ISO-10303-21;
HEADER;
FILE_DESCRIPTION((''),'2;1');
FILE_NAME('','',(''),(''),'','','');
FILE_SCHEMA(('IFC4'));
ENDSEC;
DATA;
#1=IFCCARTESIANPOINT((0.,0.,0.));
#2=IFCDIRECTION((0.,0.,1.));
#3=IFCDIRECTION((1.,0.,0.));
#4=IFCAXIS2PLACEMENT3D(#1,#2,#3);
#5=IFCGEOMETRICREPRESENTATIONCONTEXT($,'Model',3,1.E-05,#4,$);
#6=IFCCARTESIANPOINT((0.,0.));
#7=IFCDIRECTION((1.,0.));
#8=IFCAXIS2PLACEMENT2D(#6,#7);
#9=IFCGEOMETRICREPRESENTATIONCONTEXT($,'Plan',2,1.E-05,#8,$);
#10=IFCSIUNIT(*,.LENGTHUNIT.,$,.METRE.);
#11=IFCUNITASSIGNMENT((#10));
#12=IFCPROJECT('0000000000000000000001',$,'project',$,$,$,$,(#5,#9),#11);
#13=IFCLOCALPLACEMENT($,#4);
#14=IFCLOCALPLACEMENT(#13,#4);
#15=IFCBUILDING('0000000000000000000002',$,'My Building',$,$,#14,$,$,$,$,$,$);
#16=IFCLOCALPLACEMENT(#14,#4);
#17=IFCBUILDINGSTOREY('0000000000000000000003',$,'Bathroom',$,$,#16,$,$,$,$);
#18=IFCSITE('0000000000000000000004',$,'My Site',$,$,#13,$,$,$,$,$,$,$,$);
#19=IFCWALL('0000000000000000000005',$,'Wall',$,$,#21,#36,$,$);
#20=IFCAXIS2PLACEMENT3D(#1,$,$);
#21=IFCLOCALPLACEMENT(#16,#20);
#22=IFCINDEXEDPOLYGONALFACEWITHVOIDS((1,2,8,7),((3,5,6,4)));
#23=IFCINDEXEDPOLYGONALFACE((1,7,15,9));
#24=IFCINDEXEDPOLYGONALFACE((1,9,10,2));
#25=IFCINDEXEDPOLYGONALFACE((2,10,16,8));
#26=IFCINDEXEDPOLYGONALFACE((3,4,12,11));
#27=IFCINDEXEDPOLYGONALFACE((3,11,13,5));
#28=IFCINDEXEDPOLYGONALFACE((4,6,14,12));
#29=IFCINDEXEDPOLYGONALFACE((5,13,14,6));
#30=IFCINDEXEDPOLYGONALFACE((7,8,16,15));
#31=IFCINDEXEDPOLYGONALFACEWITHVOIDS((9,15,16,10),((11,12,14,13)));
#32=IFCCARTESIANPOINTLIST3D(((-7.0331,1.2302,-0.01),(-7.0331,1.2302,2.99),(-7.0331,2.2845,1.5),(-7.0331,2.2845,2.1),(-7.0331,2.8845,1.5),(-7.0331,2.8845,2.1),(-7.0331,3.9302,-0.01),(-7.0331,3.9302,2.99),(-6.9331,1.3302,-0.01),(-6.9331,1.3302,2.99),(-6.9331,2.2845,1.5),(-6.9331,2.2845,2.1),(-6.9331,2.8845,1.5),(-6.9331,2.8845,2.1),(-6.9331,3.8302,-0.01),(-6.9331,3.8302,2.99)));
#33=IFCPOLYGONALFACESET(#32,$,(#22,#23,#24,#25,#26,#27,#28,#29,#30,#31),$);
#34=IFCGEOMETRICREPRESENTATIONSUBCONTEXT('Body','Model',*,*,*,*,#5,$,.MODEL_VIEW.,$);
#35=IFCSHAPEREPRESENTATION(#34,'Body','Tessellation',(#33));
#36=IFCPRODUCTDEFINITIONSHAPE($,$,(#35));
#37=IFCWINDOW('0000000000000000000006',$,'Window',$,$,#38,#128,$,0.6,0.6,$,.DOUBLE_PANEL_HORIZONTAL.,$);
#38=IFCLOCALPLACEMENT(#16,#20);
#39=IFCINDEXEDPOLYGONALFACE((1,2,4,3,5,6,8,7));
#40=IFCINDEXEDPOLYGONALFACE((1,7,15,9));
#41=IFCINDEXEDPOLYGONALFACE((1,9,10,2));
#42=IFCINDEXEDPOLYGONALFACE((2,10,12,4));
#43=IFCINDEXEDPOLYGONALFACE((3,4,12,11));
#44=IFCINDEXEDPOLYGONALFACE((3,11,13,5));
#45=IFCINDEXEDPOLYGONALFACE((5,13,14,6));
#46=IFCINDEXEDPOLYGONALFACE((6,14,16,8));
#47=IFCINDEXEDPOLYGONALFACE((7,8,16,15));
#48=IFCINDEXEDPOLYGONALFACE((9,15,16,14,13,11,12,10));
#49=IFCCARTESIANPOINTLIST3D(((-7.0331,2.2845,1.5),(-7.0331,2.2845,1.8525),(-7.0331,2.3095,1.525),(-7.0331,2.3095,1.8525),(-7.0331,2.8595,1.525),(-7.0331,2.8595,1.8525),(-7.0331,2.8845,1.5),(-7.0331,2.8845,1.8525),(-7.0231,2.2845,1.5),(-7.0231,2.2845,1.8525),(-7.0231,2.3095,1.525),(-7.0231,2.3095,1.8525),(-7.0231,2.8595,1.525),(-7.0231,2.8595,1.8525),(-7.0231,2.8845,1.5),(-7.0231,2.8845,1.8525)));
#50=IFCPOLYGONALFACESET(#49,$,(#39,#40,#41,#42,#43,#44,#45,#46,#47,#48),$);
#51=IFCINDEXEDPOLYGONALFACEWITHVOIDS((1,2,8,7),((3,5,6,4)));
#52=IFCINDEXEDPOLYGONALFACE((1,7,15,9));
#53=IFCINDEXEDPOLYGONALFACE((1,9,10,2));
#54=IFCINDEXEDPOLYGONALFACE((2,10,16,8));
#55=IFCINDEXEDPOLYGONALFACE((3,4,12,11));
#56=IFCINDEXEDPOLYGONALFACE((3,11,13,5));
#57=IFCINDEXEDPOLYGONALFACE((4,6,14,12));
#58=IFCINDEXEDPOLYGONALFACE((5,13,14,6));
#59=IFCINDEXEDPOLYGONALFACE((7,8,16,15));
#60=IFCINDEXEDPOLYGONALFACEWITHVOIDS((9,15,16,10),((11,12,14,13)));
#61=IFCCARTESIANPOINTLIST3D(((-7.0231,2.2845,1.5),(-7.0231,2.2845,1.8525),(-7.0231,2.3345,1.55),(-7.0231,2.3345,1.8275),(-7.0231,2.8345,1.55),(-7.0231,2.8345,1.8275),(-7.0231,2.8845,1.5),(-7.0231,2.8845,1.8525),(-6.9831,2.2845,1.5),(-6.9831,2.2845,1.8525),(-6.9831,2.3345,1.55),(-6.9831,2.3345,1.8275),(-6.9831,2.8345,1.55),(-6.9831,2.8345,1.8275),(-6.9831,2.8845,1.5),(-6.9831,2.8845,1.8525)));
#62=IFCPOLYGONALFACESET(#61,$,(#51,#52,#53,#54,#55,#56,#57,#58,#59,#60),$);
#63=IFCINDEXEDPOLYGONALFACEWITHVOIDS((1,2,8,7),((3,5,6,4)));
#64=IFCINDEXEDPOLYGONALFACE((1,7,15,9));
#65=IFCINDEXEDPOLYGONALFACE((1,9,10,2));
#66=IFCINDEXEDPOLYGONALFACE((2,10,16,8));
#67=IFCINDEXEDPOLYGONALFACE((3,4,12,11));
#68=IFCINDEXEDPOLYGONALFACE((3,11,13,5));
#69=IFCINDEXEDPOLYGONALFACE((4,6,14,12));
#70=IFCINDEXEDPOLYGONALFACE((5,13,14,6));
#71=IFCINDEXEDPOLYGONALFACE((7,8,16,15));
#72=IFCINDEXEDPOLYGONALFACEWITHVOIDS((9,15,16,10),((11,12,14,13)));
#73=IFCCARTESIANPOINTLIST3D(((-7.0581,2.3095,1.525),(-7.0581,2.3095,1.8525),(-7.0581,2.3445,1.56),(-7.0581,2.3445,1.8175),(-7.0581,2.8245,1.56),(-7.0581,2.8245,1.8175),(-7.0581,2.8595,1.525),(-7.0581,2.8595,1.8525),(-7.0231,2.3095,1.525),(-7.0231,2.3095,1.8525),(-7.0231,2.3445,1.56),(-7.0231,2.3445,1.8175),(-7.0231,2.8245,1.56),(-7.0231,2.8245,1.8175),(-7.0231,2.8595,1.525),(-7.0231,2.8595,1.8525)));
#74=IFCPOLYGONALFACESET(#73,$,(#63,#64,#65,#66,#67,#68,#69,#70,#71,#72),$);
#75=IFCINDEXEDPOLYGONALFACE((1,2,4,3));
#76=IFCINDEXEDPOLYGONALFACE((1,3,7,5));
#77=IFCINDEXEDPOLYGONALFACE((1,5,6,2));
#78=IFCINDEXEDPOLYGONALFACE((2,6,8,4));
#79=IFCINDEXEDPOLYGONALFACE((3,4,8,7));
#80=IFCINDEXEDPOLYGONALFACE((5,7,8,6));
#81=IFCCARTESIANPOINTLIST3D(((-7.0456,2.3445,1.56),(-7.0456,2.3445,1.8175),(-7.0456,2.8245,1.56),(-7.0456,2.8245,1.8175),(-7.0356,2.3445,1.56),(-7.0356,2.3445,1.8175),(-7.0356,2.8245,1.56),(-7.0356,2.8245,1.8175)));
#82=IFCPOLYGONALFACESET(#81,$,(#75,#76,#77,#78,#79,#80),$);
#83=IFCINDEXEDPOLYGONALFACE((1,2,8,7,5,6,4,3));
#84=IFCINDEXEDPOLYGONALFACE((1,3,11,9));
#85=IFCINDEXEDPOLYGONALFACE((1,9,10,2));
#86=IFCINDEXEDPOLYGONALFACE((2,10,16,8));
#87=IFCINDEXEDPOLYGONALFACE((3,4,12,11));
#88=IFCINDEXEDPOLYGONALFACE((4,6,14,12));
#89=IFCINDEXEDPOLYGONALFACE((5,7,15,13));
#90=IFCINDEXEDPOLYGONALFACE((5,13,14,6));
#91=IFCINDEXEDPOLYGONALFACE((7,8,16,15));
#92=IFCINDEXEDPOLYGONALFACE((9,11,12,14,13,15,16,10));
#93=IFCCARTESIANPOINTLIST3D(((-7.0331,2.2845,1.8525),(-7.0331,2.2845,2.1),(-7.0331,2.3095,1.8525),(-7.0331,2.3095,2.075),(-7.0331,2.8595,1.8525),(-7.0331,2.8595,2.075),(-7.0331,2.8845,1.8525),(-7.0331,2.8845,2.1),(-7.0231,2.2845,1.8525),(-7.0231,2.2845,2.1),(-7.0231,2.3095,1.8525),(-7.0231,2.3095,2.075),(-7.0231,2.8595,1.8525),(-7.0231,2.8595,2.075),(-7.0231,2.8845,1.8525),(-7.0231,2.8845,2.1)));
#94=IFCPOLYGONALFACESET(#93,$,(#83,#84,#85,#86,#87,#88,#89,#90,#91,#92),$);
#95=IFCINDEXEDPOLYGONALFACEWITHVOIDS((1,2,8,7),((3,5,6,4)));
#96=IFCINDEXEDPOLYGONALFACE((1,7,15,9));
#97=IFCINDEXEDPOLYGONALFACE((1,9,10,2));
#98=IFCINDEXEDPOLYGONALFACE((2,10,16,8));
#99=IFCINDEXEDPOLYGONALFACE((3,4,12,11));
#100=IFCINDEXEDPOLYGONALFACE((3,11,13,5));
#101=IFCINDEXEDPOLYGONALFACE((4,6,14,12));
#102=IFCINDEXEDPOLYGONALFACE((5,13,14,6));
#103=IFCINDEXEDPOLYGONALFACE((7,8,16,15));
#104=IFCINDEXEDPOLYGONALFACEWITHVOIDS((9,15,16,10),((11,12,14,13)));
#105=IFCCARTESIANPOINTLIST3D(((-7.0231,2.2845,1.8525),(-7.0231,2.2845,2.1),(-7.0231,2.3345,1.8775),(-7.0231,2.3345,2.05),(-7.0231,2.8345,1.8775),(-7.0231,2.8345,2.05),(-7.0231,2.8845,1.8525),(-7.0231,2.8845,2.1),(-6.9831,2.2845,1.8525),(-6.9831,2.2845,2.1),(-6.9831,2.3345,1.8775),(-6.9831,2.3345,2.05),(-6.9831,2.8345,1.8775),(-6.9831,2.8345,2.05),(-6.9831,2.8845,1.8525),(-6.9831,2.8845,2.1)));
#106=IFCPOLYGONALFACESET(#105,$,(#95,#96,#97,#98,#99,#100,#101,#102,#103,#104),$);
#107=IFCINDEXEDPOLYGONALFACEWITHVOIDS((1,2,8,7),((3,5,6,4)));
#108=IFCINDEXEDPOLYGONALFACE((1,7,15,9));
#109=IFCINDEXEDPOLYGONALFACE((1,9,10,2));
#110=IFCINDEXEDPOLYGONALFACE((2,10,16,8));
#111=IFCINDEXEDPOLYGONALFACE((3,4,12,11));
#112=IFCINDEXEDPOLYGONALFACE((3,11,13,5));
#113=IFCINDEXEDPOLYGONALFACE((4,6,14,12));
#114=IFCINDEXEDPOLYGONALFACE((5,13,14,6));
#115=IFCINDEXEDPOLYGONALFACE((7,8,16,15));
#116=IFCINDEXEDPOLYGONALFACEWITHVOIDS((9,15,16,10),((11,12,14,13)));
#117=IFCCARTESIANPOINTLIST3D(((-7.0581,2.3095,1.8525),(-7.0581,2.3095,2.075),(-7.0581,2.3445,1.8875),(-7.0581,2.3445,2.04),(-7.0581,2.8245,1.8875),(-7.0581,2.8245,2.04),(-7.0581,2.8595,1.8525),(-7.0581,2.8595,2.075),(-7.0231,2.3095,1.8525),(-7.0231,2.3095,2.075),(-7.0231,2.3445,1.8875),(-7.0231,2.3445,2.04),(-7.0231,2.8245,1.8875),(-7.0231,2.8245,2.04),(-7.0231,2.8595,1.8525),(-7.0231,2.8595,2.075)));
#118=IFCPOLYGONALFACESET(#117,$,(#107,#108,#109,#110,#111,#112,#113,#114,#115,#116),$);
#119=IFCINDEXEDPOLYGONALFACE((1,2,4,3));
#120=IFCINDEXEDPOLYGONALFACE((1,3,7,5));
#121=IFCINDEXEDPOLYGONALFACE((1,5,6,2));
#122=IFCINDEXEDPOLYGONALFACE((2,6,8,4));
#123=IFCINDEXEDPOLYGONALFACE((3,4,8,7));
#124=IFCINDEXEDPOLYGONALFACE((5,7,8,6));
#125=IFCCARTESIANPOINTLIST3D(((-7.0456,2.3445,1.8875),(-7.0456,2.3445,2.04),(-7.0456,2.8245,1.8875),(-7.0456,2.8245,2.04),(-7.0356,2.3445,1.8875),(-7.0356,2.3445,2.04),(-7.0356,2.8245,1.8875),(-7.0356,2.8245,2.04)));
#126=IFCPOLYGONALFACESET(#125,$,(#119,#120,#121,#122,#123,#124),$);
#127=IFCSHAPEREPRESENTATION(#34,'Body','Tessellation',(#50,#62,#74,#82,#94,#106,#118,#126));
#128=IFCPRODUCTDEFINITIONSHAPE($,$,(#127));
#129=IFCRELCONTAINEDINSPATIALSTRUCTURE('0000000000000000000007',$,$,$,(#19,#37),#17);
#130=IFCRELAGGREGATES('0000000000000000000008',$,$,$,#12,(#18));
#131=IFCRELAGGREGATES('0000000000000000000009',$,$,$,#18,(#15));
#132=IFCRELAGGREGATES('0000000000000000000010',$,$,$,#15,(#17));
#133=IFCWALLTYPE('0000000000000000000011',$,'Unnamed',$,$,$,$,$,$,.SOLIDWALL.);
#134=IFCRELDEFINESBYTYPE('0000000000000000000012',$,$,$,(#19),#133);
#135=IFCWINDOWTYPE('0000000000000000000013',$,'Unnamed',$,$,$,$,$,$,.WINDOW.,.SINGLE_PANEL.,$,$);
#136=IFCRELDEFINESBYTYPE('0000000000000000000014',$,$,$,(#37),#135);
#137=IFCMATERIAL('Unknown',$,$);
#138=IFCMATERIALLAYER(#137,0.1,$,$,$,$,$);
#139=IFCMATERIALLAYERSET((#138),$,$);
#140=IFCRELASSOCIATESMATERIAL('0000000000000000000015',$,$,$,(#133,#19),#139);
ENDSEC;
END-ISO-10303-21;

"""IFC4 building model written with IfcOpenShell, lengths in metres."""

from ifc_helpers import new_model, entity, si_unit, frame, origin_with_axes, origin_2d_with_axis, place, context, subcontext, project, spatial, line, indexed_curve, outline, extrude, shape, source, transform, mapped, material, layer, layer_set, layer_usage, type_object, type_shapes, element, fill, save


model = new_model("IFC4")

# Units and contexts
model_context = context("Model", 3, precision=1e-05, world=origin_with_axes())
plan_context = context("Plan", 2, precision=1e-05, world=origin_2d_with_axis())
body_context_1 = subcontext(model_context, "Body", "Model", "MODEL_VIEW")
body_context_2 = subcontext(plan_context, "Body", "Plan", "PLAN_VIEW")
ifc_project = project(units=[si_unit("LENGTHUNIT", "METRE")], contexts=[model_context, plan_context])

# Site, building, storey
site_placement = place(None, origin_with_axes())
site = spatial("IfcSite", under=ifc_project, at=site_placement, Name="My Site")
building_placement = place(site_placement, origin_with_axes())
building = spatial("IfcBuilding", under=site, at=building_placement, Name="My Building")
storey_placement = place(building_placement, origin_with_axes())
storey = spatial("IfcBuildingStorey", under=building, at=storey_placement, Name="Bathroom")

# Shared definitions
ifc_material = material(Name="Unknown")

# Shared definitions
ifc_layer_1 = layer(ifc_material, 0.1)
ifc_layer_set_1 = layer_set([ifc_layer_1])
wall_type = type_object("IfcWallType", Name="Unnamed", PredefinedType="SOLIDWALL", material=ifc_layer_set_1)

# Shared definitions
shared_shape_1 = source(origin_with_axes(), body_context_1, "Body", "SweptSolid", [
    extrude(outline(indexed_curve([(0.0, 0.0), (0.6, 0.0), (0.6, 0.6), (0.0, 0.6)], segments=[line(1, 2, 3, 4, 1)])), frame((0.0, -0.6, 0.0), z_axis=(0.0, -1.0, 0.0), x_axis=(1.0, 0.0, 0.0)), (0.0, 0.0, -1.0), 1.2),
])
window_type = type_object("IfcWindowType", Name="Unnamed", PartitioningType="SINGLE_PANEL", PredefinedType="WINDOW")
shared_shape_2 = source(origin_with_axes(), body_context_1, "Body", "SweptSolid", [
    extrude(outline(indexed_curve([(0.6, 0.3525), (0.6, 0.0), (0.0, 0.0), (0.0, 0.3525), (0.025, 0.3525), (0.025, 0.025), (0.575, 0.025), (0.575, 0.3525)], segments=[line(1, 2, 3, 4, 5, 6, 7, 8, 1)])), frame((0.0, 0.09, 0.0), z_axis=(0.0, -1.0, 0.0), x_axis=(1.0, 0.0, 0.0)), (0.0, 0.0, -1.0), 0.01),
    extrude(outline(indexed_curve([(0.0, 0.0), (0.6, 0.0), (0.6, 0.3525), (0.0, 0.3525)], segments=[line(1, 2, 3, 4, 1)]), holes=[indexed_curve([(0.05, 0.05), (0.55, 0.05), (0.55, 0.3275), (0.05, 0.3275)], segments=[line(1, 2, 3, 4, 1)])]), frame((0.0, 0.05, 0.0), z_axis=(0.0, -1.0, 0.0), x_axis=(1.0, 0.0, 0.0)), (0.0, 0.0, -1.0), 0.04),
    extrude(outline(indexed_curve([(0.0, 0.0), (0.55, 0.0), (0.55, 0.3275), (0.0, 0.3275)], segments=[line(1, 2, 3, 4, 1)]), holes=[indexed_curve([(0.035, 0.035), (0.515, 0.035), (0.515, 0.2925), (0.035, 0.2925)], segments=[line(1, 2, 3, 4, 1)])]), frame((0.025, 0.09, 0.025), z_axis=(0.0, -1.0, 0.0), x_axis=(1.0, 0.0, 0.0)), (0.0, 0.0, -1.0), 0.035),
    extrude(outline(indexed_curve([(0.035, 0.035), (0.515, 0.035), (0.515, 0.2925), (0.035, 0.2925)], segments=[line(1, 2, 3, 4, 1)])), frame((0.025, 0.1025, 0.025), z_axis=(0.0, -1.0, 0.0), x_axis=(1.0, 0.0, 0.0)), (0.0, 0.0, -1.0), 0.01),
    extrude(outline(indexed_curve([(0.0, 0.0), (0.0, 0.2475), (0.6, 0.2475), (0.6, 0.0), (0.575, 0.0), (0.575, 0.2225), (0.025, 0.2225), (0.025, 0.0)], segments=[line(1, 2, 3, 4, 5, 6, 7, 8, 1)])), frame((0.0, 0.09, 0.3525), z_axis=(0.0, -1.0, 0.0), x_axis=(1.0, 0.0, 0.0)), (0.0, 0.0, -1.0), 0.01),
    extrude(outline(indexed_curve([(0.0, 0.0), (0.6, 0.0), (0.6, 0.2475), (0.0, 0.2475)], segments=[line(1, 2, 3, 4, 1)]), holes=[indexed_curve([(0.05, 0.025), (0.55, 0.025), (0.55, 0.1975), (0.05, 0.1975)], segments=[line(1, 2, 3, 4, 1)])]), frame((0.0, 0.05, 0.3525), z_axis=(0.0, -1.0, 0.0), x_axis=(1.0, 0.0, 0.0)), (0.0, 0.0, -1.0), 0.04),
    extrude(outline(indexed_curve([(0.0, 0.0), (0.55, 0.0), (0.55, 0.2225), (0.0, 0.2225)], segments=[line(1, 2, 3, 4, 1)]), holes=[indexed_curve([(0.035, 0.035), (0.515, 0.035), (0.515, 0.1875), (0.035, 0.1875)], segments=[line(1, 2, 3, 4, 1)])]), frame((0.025, 0.09, 0.3525), z_axis=(0.0, -1.0, 0.0), x_axis=(1.0, 0.0, 0.0)), (0.0, 0.0, -1.0), 0.035),
    extrude(outline(indexed_curve([(0.035, 0.035), (0.515, 0.035), (0.515, 0.1875), (0.035, 0.1875)], segments=[line(1, 2, 3, 4, 1)])), frame((0.025, 0.1025, 0.3525), z_axis=(0.0, -1.0, 0.0), x_axis=(1.0, 0.0, 0.0)), (0.0, 0.0, -1.0), 0.01),
])
shared_shape_3 = source(origin_with_axes(), body_context_2, "Body", "Curve2D", [
    entity("IfcIndexedPolyCurve", entity("IfcCartesianPointList2D", [[0.05, 0.05], [0.55, 0.05]])),
    entity("IfcIndexedPolyCurve", entity("IfcCartesianPointList2D", [[0.0, 0.1], [0.025, 0.1], [0.025, 0.09], [0.05, 0.09], [0.05, 0.05], [0.0, 0.05]]), [entity("IfcLineIndex", [1, 2, 3, 4, 5, 6, 1])]),
    entity("IfcIndexedPolyCurve", entity("IfcCartesianPointList2D", [[0.6, 0.1], [0.575, 0.1], [0.575, 0.09], [0.55, 0.09], [0.55, 0.05], [0.6, 0.05]]), [entity("IfcLineIndex", [1, 2, 3, 4, 5, 6, 1])]),
    entity("IfcIndexedPolyCurve", entity("IfcCartesianPointList2D", [[0.025, 0.09], [0.06, 0.09], [0.06, 0.125], [0.025, 0.125]]), [entity("IfcLineIndex", [1, 2, 3, 4, 1])]),
    entity("IfcIndexedPolyCurve", entity("IfcCartesianPointList2D", [[0.575, 0.09], [0.54, 0.09], [0.54, 0.125], [0.575, 0.125]]), [entity("IfcLineIndex", [1, 2, 3, 4, 1])]),
    entity("IfcIndexedPolyCurve", entity("IfcCartesianPointList2D", [[0.06, 0.09], [0.54, 0.09]])),
    entity("IfcIndexedPolyCurve", entity("IfcCartesianPointList2D", [[0.06, 0.125], [0.54, 0.125]])),
    entity("IfcIndexedPolyCurve", entity("IfcCartesianPointList2D", [[0.06, 0.1075], [0.54, 0.1075]])),
])
type_shapes(window_type, [shared_shape_2, shared_shape_3])

# Wall, opening, window
ifc_layer_usage_1 = layer_usage(ifc_layer_set_1, "AXIS2", "POSITIVE", 0.0)
wall_1_placement = place(storey_placement, frame((-7.0331, 3.9302, -0.01), z_axis=(0.0, 0.0, 1.0), x_axis=(0.0, -1.0, 0.0)))
wall_1 = element("IfcWall", 1, at=wall_1_placement, inside=storey, type_object=wall_type, material=ifc_layer_usage_1, Name="Wall", context=body_context_1, shape_type="SweptSolid", body=[
    extrude(outline(indexed_curve([(0.0, 0.0), (0.1, 0.1), (2.6, 0.1), (2.7, 0.0)], segments=[line(1, 2, 3, 4, 1)])), origin_with_axes(), (0.0, 0.0, 1.0), 3.0),
])
opening_1_placement = place(wall_1_placement, frame((1.6457, 0.1, 1.51), z_axis=(0.0, 0.0, 1.0), x_axis=(-1.0, 0.0, 0.0)))
opening_1 = element("IfcOpeningElement", 2, at=opening_1_placement, cuts=wall_1, PredefinedType="OPENING", context=body_context_1, shape_type="MappedRepresentation", body=[
    mapped(shared_shape_1, transform((0.0, 0.0, 0.0), x_axis=(1.0, 0.0, 0.0), y_axis=(0.0, 1.0, 0.0), z_axis=(0.0, 0.0, 1.0), scale=1.0)),
])
window_1_placement = place(opening_1_placement, frame((0.0, 0.0, 0.0), z_axis=(0.0, 0.0, 1.0), x_axis=(1.0, 0.0, 0.0)))
window_1 = element("IfcWindow", 3, at=window_1_placement, inside=storey, type_object=window_type, Name="Window", OverallHeight=0.6, OverallWidth=0.6, PartitioningType="DOUBLE_PANEL_HORIZONTAL", shapes=[
    shape(body_context_1, "Body", "MappedRepresentation", [mapped(shared_shape_2, transform((0.0, 0.0, 0.0), x_axis=(1.0, 0.0, 0.0), y_axis=(0.0, 1.0, 0.0), z_axis=(0.0, 0.0, 1.0), scale=1.0))]),
    shape(body_context_2, "Body", "MappedRepresentation", [mapped(shared_shape_3, transform((0.0, 0.0, 0.0), x_axis=(1.0, 0.0, 0.0), y_axis=(0.0, 1.0, 0.0), z_axis=(0.0, 0.0, 1.0), scale=1.0))]),
])
fill(opening_1, window_1)

save(model, "model.ifc")
